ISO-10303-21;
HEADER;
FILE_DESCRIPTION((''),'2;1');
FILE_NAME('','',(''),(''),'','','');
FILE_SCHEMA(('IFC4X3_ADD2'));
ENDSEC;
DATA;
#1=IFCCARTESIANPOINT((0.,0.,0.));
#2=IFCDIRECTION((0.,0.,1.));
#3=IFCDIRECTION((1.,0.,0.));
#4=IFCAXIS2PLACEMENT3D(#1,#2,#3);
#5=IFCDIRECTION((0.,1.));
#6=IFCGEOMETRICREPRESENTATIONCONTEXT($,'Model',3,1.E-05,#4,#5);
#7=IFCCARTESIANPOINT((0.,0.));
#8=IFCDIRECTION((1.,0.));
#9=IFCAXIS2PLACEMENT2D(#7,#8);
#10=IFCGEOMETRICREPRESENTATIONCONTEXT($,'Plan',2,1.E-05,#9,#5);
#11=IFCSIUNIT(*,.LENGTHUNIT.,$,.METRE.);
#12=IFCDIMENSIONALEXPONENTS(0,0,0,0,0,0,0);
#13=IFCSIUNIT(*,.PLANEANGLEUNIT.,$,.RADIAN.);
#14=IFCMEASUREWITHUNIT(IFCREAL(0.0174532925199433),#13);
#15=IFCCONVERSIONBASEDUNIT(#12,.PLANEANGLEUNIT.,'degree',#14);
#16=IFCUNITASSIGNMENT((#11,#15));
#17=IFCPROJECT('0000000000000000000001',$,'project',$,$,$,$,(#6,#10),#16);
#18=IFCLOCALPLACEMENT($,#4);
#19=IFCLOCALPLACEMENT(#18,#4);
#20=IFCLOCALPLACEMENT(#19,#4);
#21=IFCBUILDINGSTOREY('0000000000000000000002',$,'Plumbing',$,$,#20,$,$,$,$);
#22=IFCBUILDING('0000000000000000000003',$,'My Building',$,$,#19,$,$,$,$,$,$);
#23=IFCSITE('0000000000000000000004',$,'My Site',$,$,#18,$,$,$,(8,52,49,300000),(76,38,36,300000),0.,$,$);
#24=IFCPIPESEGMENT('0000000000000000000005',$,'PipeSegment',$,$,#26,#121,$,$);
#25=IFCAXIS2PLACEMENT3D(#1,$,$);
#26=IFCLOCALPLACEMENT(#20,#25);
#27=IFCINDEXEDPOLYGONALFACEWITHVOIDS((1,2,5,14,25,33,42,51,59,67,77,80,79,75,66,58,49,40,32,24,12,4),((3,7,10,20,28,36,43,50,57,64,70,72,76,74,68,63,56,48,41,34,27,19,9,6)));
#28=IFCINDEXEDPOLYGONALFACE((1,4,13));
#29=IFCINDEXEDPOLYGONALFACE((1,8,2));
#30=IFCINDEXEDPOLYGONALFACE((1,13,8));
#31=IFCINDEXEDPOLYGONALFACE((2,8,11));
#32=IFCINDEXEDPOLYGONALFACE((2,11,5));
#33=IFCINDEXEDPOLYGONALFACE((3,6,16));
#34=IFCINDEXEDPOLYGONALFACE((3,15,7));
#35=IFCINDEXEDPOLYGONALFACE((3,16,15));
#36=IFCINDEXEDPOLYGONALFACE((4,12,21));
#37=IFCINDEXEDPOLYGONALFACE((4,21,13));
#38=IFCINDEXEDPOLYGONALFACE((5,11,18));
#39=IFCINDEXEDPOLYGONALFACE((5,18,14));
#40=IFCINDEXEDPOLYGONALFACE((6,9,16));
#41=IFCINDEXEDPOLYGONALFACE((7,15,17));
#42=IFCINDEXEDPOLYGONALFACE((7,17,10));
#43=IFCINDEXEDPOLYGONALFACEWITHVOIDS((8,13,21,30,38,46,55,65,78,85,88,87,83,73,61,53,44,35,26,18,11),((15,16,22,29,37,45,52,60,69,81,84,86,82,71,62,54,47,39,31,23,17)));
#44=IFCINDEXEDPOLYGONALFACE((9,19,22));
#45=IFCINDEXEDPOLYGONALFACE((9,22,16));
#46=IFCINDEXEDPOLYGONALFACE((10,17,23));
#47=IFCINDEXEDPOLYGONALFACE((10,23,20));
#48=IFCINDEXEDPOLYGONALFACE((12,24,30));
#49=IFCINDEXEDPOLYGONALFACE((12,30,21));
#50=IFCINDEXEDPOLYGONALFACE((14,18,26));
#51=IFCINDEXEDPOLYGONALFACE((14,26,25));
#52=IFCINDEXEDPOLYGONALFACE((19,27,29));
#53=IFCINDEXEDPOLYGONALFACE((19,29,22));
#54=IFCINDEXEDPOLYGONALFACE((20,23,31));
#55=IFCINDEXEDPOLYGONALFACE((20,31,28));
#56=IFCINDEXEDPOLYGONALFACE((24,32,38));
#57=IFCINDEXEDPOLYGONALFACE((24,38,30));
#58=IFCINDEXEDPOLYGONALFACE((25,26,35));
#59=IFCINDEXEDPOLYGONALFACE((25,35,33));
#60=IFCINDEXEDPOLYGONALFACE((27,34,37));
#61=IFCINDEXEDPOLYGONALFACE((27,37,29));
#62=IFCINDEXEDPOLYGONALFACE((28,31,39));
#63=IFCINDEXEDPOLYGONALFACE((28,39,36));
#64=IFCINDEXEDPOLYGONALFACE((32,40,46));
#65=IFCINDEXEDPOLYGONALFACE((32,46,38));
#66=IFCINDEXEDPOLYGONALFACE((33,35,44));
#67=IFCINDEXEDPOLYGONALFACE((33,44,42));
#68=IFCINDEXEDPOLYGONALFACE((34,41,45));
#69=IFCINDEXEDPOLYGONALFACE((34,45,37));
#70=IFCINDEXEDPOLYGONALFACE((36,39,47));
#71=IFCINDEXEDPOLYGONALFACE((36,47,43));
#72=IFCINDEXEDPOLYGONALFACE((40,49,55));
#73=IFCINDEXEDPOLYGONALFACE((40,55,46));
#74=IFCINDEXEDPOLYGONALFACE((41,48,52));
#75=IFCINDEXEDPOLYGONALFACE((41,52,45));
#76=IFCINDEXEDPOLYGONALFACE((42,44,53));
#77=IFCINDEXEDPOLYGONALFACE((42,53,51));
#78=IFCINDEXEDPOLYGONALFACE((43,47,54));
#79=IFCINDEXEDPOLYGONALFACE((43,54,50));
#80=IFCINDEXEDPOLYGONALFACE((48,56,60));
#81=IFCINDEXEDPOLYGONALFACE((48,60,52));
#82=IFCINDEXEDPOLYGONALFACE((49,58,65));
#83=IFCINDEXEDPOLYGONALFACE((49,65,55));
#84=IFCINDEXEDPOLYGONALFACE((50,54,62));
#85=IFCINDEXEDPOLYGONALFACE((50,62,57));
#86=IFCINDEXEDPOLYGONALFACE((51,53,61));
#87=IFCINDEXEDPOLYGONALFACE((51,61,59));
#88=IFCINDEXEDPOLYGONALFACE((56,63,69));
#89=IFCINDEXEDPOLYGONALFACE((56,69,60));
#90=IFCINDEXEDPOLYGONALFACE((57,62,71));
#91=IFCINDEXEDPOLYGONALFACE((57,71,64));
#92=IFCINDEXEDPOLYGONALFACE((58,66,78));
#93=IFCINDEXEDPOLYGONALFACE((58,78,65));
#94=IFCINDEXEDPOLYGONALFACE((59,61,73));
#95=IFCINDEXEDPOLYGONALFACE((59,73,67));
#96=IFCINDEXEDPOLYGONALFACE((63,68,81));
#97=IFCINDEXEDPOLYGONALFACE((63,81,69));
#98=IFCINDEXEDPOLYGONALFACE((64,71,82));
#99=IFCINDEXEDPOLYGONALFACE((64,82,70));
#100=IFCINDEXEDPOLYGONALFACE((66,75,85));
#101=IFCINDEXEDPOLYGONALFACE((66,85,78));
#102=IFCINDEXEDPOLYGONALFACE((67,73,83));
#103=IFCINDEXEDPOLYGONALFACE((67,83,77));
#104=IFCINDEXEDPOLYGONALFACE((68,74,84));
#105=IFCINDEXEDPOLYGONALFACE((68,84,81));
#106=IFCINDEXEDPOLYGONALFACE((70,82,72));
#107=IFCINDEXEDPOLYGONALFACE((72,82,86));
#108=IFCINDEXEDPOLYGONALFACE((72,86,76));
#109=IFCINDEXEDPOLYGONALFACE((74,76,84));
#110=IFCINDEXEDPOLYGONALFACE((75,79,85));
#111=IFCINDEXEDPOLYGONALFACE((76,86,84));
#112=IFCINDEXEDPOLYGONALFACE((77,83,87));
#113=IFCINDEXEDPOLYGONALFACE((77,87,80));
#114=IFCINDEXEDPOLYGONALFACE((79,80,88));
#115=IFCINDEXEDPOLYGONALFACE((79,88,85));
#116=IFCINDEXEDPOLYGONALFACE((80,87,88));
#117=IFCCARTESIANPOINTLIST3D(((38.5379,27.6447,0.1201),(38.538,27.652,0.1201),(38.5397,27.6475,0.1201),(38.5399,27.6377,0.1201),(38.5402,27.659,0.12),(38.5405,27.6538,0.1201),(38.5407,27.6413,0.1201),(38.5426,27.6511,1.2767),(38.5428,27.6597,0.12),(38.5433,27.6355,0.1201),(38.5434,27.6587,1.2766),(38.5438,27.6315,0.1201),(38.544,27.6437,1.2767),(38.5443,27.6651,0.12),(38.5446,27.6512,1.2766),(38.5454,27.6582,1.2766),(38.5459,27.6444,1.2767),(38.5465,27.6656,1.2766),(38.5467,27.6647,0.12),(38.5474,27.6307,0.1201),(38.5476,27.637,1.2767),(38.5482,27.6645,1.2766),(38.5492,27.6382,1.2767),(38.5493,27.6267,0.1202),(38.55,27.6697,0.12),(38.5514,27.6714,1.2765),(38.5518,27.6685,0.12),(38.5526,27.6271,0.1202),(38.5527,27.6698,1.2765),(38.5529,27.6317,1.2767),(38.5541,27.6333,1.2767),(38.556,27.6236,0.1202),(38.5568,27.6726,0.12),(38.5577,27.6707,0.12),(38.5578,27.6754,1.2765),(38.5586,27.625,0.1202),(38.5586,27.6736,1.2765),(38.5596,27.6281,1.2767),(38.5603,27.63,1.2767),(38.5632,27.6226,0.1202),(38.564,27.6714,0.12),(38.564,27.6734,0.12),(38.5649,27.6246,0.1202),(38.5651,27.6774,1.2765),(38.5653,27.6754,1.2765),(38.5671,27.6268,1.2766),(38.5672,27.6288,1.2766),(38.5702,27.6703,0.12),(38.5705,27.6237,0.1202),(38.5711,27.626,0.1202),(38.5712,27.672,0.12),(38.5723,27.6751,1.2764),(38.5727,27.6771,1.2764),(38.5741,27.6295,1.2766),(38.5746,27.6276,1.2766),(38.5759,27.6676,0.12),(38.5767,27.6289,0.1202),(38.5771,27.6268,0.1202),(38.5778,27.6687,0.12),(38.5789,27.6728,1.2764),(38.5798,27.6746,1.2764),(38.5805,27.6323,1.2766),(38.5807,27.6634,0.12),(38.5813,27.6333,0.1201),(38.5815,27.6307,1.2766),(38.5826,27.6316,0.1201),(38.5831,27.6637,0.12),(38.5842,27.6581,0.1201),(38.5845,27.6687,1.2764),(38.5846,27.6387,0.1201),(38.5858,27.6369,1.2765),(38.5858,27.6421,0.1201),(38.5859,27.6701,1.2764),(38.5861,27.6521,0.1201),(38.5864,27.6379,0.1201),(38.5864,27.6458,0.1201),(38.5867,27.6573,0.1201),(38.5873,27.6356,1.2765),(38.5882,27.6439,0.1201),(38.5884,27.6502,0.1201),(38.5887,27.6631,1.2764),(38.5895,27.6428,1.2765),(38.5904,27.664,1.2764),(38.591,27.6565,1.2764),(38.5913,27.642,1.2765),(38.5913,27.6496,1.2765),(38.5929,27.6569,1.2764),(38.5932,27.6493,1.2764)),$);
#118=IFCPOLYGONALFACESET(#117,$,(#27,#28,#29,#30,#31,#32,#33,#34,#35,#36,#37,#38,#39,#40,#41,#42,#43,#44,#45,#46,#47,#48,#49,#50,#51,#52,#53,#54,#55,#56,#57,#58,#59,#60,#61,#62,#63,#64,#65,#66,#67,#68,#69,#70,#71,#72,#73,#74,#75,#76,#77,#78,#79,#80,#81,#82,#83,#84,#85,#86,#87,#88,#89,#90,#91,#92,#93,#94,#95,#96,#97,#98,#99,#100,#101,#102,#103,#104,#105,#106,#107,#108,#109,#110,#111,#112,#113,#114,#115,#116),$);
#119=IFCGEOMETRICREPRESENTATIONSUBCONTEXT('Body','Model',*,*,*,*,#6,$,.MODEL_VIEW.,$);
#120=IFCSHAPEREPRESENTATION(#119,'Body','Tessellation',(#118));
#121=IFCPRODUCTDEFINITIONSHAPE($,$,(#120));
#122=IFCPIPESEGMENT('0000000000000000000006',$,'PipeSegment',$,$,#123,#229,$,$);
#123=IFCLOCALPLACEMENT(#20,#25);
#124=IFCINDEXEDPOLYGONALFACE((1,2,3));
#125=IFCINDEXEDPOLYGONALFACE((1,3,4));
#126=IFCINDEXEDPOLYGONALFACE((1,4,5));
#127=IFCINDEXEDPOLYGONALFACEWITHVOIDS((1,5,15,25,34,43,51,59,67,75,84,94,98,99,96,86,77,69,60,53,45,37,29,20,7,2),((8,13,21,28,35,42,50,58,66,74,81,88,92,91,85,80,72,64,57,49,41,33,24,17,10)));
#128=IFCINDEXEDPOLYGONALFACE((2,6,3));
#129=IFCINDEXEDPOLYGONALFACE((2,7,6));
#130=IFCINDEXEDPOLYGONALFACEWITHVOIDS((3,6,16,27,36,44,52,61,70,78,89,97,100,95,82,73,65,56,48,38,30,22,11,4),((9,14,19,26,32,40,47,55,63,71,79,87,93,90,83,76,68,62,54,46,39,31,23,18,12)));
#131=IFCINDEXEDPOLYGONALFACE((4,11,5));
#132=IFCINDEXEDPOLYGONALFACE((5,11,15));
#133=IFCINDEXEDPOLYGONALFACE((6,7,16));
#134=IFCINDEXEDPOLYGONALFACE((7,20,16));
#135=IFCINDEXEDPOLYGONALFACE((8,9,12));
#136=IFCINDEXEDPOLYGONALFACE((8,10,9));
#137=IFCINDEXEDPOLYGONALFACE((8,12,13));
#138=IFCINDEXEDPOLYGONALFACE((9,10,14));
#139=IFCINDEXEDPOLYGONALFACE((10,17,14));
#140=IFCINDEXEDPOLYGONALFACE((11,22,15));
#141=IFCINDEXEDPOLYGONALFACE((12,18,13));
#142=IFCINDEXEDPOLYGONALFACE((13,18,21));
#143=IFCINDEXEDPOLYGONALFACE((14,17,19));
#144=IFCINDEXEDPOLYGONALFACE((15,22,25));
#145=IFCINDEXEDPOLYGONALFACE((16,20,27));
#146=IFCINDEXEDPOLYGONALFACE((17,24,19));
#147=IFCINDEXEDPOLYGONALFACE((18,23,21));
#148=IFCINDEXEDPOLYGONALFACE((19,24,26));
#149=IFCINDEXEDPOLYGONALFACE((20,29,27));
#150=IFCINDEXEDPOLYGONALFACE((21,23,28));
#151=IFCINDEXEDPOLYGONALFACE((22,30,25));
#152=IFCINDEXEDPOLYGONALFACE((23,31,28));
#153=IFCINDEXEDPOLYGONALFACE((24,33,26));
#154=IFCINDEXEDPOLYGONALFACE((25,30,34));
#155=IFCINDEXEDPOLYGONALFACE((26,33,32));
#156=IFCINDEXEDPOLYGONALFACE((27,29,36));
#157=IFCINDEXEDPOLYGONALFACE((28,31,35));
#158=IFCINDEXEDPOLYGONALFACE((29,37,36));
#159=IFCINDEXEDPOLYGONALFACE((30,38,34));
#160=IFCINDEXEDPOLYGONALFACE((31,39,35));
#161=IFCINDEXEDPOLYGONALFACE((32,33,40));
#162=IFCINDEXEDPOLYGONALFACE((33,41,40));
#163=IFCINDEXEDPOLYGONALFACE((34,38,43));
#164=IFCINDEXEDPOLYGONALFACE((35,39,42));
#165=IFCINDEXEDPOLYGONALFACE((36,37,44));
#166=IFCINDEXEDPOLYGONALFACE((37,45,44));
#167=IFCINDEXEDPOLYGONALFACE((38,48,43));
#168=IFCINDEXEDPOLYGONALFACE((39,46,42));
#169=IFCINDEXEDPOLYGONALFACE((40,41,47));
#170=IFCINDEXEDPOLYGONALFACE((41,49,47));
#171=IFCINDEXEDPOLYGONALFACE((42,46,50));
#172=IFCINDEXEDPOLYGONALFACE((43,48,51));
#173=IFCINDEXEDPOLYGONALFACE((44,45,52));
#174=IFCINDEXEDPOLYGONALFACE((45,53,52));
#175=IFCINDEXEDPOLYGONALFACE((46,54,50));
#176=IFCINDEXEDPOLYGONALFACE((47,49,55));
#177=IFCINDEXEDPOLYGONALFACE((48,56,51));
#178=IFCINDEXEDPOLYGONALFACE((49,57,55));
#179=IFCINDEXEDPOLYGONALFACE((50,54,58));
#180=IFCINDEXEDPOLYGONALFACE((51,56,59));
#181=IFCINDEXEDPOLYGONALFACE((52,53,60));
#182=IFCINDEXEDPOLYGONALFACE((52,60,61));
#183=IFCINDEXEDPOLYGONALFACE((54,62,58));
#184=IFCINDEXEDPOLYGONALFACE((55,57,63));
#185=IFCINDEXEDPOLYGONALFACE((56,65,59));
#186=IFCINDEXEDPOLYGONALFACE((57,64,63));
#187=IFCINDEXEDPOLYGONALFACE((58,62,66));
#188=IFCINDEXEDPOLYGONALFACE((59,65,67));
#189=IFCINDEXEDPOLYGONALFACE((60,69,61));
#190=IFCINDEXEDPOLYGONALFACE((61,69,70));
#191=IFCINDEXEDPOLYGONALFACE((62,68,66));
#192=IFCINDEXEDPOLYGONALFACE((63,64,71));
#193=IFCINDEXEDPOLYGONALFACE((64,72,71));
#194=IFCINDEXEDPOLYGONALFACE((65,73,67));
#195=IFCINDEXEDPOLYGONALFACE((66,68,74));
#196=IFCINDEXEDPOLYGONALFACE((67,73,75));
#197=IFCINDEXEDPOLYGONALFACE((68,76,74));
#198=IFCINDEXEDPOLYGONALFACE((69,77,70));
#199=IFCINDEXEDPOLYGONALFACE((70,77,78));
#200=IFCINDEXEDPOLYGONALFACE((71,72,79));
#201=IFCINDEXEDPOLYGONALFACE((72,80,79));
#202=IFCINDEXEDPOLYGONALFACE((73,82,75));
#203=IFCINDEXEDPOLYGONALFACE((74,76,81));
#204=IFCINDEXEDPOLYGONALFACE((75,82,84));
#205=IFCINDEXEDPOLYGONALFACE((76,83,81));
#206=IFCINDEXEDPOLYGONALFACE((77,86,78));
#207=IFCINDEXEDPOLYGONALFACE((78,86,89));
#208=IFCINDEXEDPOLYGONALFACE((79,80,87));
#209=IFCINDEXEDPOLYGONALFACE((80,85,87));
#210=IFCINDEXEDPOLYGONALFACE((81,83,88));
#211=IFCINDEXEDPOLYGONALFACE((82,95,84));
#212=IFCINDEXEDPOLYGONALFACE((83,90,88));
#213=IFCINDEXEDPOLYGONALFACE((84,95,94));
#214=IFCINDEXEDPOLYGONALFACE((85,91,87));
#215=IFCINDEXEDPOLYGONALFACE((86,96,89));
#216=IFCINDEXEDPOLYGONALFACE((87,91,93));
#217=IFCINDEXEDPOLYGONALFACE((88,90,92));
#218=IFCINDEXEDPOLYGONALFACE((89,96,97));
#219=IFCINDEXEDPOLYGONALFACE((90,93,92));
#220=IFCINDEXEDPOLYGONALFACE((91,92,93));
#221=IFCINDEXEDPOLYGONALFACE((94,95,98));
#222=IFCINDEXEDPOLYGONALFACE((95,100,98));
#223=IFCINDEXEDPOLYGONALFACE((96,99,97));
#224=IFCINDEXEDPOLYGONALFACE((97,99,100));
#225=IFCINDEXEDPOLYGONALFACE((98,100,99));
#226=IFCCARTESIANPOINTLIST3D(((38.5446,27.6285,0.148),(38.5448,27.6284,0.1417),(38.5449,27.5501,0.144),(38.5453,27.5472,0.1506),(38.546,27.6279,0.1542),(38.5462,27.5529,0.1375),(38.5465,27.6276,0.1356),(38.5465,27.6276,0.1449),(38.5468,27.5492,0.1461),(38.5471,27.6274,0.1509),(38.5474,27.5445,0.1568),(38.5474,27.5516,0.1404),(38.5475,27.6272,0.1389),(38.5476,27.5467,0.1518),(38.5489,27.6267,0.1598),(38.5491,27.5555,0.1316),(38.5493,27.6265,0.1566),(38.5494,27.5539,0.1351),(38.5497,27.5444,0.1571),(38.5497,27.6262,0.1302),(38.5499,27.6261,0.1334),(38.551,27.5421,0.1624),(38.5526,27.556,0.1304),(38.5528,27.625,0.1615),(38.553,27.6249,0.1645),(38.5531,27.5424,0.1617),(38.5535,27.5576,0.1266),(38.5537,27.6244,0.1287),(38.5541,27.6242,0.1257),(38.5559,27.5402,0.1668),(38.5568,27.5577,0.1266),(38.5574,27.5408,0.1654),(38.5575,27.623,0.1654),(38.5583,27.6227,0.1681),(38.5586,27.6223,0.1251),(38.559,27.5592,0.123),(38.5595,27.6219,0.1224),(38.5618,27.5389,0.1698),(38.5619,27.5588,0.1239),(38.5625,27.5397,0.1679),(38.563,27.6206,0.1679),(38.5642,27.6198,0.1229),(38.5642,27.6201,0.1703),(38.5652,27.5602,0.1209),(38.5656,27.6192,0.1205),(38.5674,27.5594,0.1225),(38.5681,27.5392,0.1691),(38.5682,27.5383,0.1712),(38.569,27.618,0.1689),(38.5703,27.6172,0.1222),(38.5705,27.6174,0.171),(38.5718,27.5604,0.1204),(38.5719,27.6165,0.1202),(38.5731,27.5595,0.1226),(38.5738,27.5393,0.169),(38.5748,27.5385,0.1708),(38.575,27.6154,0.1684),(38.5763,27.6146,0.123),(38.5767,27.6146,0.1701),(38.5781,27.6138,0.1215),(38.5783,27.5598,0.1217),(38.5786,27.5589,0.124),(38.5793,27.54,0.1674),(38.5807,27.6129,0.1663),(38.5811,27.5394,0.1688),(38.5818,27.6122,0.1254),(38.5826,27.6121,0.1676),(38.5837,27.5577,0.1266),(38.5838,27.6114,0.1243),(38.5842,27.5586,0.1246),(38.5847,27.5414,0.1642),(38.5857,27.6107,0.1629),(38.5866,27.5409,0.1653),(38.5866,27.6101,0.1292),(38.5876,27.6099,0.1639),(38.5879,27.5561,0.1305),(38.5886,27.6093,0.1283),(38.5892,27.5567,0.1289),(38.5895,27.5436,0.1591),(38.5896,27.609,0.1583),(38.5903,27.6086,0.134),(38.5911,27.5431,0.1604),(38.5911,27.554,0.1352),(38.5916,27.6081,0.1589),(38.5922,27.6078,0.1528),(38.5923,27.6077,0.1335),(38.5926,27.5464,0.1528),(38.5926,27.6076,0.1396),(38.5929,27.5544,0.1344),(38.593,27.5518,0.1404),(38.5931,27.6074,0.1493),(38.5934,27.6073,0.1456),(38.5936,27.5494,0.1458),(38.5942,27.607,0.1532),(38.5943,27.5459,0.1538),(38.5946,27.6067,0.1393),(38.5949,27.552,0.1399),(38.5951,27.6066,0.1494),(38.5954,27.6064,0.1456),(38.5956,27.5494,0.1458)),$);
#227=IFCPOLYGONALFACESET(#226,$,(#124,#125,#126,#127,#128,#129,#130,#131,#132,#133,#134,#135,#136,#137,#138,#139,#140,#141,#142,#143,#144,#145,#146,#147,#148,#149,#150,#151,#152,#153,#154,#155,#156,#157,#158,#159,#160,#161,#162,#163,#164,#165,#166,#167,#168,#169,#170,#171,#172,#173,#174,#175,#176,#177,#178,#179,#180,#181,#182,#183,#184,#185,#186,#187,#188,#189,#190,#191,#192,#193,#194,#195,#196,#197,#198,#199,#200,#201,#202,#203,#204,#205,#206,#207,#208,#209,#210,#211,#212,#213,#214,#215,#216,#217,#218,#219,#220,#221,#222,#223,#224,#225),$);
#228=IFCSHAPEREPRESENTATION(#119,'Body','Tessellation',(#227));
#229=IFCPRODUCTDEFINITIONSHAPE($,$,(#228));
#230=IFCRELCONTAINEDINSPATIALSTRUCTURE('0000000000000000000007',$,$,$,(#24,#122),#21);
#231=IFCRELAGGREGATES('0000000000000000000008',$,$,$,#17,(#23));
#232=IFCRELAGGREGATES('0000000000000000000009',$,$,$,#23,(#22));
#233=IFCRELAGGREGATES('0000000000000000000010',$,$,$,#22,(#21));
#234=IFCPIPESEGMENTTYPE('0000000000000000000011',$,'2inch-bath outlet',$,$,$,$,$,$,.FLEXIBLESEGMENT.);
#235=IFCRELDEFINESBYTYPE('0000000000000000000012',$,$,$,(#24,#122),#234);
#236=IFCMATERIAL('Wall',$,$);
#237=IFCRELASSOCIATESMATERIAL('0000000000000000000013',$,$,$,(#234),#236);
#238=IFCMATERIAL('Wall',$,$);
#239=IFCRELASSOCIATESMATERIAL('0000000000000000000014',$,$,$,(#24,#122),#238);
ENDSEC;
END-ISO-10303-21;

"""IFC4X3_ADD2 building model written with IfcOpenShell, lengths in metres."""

from ifc_helpers import new_model, entity, si_unit, converted_unit, direction, frame, origin_with_axes, origin_2d_with_axis, place, context, subcontext, project, spatial, hollow_circle, extrude, clip, halfspace, material, material_profile, profile_set, profile_usage, type_object, element, save


model = new_model("IFC4X3_ADD2")

# Units and contexts
model_context = context("Model", 3, precision=1e-05, world=origin_with_axes(), true_north=direction((0.0, 1.0)))
plan_context = context("Plan", 2, precision=1e-05, world=origin_2d_with_axis(), true_north=direction((0.0, 1.0)))
body_context = subcontext(model_context, "Body", "Model", "MODEL_VIEW")
ifc_project = project(units=[si_unit("LENGTHUNIT", "METRE"), converted_unit("PLANEANGLEUNIT", "degree", entity("IfcReal", 0.0174532925199433), si_unit("PLANEANGLEUNIT", "RADIAN"), dimensions=[0, 0, 0, 0, 0, 0, 0])], contexts=[model_context, plan_context])

# Site, building, storey
site_placement = place(None, origin_with_axes())
site = spatial("IfcSite", under=ifc_project, at=site_placement, Name="My Site", RefLatitude=(8, 52, 49, 300000), RefLongitude=(76, 38, 36, 300000), RefElevation=0.0)
building_placement = place(site_placement, origin_with_axes())
building = spatial("IfcBuilding", under=site, at=building_placement, Name="My Building")
storey_placement = place(building_placement, origin_with_axes())
storey = spatial("IfcBuildingStorey", under=building, at=storey_placement, Name="Plumbing")

# Pipe segments
ifc_material_1 = material(Name="Wall")
ifc_material_profile_1 = material_profile(ifc_material_1, hollow_circle(Radius=0.0254, WallThickness=0.002))
ifc_profile_set_1 = profile_set([ifc_material_profile_1], Name="graywater")
ifc_profile_usage_1 = profile_usage(ifc_profile_set_1, cardinal=5)
ifc_material_2 = material(Name="Wall")
ifc_material_profile_2 = material_profile(ifc_material_2, hollow_circle(Radius=0.0254, WallThickness=0.002))
ifc_profile_set_2 = profile_set([ifc_material_profile_2], Name="graywater")
pipe_segment_type_1 = type_object("IfcPipeSegmentType", Name="2inch-bath outlet", PredefinedType="FLEXIBLESEGMENT", material=ifc_profile_set_2)
pipe_segment_1_placement = place(storey_placement, frame((38.5629, 27.6478, 0.0693), z_axis=(0.004219, 0.003594, 0.999985), x_axis=(0.917305, -0.398179, -0.002439)))
element("IfcPipeSegment", 1, at=pipe_segment_1_placement, inside=storey, type_object=pipe_segment_type_1, material=ifc_profile_usage_1, Name="PipeSegment", context=body_context, shape_type="Clipping", body=[
    clip(extrude(hollow_circle(Radius=0.0254, WallThickness=0.002), origin_with_axes(), (0.0, 0.0, 1.0), 1.2073), halfspace(frame((-0.0242, 0.0719, 0.0508), z_axis=(0.003884, 0.001686, -0.999991), x_axis=(0.999992, 0.0, 0.003884)), False)),
])
ifc_profile_usage_2 = profile_usage(ifc_profile_set_1, cardinal=5)
pipe_segment_2_placement = place(storey_placement, frame((38.5697, 27.6682, 0.1454), z_axis=(0.004187, -0.999985, 0.003595), x_axis=(0.999991, 0.004187, 0.0)))
element("IfcPipeSegment", 2, at=pipe_segment_2_placement, inside=storey, type_object=pipe_segment_type_1, material=ifc_profile_usage_2, Name="PipeSegment", context=body_context, shape_type="Clipping", body=[
    clip(clip(extrude(hollow_circle(Radius=0.0254, WallThickness=0.002), origin_with_axes(), (0.0, 0.0, 1.0), 0.1696), halfspace(frame((0.5693, 0.0108, 0.1245), z_axis=(-0.001402, -0.401474, 0.915869), x_axis=(-0.999994, 0.003492, 0.0)), False)), halfspace(frame((-0.0171, -0.0761, 0.0434), z_axis=(0.402001, -0.001686, -0.915638), x_axis=(-0.004193, -0.999991, 0.0)), False)),
])

save(model, "model.ifc")
